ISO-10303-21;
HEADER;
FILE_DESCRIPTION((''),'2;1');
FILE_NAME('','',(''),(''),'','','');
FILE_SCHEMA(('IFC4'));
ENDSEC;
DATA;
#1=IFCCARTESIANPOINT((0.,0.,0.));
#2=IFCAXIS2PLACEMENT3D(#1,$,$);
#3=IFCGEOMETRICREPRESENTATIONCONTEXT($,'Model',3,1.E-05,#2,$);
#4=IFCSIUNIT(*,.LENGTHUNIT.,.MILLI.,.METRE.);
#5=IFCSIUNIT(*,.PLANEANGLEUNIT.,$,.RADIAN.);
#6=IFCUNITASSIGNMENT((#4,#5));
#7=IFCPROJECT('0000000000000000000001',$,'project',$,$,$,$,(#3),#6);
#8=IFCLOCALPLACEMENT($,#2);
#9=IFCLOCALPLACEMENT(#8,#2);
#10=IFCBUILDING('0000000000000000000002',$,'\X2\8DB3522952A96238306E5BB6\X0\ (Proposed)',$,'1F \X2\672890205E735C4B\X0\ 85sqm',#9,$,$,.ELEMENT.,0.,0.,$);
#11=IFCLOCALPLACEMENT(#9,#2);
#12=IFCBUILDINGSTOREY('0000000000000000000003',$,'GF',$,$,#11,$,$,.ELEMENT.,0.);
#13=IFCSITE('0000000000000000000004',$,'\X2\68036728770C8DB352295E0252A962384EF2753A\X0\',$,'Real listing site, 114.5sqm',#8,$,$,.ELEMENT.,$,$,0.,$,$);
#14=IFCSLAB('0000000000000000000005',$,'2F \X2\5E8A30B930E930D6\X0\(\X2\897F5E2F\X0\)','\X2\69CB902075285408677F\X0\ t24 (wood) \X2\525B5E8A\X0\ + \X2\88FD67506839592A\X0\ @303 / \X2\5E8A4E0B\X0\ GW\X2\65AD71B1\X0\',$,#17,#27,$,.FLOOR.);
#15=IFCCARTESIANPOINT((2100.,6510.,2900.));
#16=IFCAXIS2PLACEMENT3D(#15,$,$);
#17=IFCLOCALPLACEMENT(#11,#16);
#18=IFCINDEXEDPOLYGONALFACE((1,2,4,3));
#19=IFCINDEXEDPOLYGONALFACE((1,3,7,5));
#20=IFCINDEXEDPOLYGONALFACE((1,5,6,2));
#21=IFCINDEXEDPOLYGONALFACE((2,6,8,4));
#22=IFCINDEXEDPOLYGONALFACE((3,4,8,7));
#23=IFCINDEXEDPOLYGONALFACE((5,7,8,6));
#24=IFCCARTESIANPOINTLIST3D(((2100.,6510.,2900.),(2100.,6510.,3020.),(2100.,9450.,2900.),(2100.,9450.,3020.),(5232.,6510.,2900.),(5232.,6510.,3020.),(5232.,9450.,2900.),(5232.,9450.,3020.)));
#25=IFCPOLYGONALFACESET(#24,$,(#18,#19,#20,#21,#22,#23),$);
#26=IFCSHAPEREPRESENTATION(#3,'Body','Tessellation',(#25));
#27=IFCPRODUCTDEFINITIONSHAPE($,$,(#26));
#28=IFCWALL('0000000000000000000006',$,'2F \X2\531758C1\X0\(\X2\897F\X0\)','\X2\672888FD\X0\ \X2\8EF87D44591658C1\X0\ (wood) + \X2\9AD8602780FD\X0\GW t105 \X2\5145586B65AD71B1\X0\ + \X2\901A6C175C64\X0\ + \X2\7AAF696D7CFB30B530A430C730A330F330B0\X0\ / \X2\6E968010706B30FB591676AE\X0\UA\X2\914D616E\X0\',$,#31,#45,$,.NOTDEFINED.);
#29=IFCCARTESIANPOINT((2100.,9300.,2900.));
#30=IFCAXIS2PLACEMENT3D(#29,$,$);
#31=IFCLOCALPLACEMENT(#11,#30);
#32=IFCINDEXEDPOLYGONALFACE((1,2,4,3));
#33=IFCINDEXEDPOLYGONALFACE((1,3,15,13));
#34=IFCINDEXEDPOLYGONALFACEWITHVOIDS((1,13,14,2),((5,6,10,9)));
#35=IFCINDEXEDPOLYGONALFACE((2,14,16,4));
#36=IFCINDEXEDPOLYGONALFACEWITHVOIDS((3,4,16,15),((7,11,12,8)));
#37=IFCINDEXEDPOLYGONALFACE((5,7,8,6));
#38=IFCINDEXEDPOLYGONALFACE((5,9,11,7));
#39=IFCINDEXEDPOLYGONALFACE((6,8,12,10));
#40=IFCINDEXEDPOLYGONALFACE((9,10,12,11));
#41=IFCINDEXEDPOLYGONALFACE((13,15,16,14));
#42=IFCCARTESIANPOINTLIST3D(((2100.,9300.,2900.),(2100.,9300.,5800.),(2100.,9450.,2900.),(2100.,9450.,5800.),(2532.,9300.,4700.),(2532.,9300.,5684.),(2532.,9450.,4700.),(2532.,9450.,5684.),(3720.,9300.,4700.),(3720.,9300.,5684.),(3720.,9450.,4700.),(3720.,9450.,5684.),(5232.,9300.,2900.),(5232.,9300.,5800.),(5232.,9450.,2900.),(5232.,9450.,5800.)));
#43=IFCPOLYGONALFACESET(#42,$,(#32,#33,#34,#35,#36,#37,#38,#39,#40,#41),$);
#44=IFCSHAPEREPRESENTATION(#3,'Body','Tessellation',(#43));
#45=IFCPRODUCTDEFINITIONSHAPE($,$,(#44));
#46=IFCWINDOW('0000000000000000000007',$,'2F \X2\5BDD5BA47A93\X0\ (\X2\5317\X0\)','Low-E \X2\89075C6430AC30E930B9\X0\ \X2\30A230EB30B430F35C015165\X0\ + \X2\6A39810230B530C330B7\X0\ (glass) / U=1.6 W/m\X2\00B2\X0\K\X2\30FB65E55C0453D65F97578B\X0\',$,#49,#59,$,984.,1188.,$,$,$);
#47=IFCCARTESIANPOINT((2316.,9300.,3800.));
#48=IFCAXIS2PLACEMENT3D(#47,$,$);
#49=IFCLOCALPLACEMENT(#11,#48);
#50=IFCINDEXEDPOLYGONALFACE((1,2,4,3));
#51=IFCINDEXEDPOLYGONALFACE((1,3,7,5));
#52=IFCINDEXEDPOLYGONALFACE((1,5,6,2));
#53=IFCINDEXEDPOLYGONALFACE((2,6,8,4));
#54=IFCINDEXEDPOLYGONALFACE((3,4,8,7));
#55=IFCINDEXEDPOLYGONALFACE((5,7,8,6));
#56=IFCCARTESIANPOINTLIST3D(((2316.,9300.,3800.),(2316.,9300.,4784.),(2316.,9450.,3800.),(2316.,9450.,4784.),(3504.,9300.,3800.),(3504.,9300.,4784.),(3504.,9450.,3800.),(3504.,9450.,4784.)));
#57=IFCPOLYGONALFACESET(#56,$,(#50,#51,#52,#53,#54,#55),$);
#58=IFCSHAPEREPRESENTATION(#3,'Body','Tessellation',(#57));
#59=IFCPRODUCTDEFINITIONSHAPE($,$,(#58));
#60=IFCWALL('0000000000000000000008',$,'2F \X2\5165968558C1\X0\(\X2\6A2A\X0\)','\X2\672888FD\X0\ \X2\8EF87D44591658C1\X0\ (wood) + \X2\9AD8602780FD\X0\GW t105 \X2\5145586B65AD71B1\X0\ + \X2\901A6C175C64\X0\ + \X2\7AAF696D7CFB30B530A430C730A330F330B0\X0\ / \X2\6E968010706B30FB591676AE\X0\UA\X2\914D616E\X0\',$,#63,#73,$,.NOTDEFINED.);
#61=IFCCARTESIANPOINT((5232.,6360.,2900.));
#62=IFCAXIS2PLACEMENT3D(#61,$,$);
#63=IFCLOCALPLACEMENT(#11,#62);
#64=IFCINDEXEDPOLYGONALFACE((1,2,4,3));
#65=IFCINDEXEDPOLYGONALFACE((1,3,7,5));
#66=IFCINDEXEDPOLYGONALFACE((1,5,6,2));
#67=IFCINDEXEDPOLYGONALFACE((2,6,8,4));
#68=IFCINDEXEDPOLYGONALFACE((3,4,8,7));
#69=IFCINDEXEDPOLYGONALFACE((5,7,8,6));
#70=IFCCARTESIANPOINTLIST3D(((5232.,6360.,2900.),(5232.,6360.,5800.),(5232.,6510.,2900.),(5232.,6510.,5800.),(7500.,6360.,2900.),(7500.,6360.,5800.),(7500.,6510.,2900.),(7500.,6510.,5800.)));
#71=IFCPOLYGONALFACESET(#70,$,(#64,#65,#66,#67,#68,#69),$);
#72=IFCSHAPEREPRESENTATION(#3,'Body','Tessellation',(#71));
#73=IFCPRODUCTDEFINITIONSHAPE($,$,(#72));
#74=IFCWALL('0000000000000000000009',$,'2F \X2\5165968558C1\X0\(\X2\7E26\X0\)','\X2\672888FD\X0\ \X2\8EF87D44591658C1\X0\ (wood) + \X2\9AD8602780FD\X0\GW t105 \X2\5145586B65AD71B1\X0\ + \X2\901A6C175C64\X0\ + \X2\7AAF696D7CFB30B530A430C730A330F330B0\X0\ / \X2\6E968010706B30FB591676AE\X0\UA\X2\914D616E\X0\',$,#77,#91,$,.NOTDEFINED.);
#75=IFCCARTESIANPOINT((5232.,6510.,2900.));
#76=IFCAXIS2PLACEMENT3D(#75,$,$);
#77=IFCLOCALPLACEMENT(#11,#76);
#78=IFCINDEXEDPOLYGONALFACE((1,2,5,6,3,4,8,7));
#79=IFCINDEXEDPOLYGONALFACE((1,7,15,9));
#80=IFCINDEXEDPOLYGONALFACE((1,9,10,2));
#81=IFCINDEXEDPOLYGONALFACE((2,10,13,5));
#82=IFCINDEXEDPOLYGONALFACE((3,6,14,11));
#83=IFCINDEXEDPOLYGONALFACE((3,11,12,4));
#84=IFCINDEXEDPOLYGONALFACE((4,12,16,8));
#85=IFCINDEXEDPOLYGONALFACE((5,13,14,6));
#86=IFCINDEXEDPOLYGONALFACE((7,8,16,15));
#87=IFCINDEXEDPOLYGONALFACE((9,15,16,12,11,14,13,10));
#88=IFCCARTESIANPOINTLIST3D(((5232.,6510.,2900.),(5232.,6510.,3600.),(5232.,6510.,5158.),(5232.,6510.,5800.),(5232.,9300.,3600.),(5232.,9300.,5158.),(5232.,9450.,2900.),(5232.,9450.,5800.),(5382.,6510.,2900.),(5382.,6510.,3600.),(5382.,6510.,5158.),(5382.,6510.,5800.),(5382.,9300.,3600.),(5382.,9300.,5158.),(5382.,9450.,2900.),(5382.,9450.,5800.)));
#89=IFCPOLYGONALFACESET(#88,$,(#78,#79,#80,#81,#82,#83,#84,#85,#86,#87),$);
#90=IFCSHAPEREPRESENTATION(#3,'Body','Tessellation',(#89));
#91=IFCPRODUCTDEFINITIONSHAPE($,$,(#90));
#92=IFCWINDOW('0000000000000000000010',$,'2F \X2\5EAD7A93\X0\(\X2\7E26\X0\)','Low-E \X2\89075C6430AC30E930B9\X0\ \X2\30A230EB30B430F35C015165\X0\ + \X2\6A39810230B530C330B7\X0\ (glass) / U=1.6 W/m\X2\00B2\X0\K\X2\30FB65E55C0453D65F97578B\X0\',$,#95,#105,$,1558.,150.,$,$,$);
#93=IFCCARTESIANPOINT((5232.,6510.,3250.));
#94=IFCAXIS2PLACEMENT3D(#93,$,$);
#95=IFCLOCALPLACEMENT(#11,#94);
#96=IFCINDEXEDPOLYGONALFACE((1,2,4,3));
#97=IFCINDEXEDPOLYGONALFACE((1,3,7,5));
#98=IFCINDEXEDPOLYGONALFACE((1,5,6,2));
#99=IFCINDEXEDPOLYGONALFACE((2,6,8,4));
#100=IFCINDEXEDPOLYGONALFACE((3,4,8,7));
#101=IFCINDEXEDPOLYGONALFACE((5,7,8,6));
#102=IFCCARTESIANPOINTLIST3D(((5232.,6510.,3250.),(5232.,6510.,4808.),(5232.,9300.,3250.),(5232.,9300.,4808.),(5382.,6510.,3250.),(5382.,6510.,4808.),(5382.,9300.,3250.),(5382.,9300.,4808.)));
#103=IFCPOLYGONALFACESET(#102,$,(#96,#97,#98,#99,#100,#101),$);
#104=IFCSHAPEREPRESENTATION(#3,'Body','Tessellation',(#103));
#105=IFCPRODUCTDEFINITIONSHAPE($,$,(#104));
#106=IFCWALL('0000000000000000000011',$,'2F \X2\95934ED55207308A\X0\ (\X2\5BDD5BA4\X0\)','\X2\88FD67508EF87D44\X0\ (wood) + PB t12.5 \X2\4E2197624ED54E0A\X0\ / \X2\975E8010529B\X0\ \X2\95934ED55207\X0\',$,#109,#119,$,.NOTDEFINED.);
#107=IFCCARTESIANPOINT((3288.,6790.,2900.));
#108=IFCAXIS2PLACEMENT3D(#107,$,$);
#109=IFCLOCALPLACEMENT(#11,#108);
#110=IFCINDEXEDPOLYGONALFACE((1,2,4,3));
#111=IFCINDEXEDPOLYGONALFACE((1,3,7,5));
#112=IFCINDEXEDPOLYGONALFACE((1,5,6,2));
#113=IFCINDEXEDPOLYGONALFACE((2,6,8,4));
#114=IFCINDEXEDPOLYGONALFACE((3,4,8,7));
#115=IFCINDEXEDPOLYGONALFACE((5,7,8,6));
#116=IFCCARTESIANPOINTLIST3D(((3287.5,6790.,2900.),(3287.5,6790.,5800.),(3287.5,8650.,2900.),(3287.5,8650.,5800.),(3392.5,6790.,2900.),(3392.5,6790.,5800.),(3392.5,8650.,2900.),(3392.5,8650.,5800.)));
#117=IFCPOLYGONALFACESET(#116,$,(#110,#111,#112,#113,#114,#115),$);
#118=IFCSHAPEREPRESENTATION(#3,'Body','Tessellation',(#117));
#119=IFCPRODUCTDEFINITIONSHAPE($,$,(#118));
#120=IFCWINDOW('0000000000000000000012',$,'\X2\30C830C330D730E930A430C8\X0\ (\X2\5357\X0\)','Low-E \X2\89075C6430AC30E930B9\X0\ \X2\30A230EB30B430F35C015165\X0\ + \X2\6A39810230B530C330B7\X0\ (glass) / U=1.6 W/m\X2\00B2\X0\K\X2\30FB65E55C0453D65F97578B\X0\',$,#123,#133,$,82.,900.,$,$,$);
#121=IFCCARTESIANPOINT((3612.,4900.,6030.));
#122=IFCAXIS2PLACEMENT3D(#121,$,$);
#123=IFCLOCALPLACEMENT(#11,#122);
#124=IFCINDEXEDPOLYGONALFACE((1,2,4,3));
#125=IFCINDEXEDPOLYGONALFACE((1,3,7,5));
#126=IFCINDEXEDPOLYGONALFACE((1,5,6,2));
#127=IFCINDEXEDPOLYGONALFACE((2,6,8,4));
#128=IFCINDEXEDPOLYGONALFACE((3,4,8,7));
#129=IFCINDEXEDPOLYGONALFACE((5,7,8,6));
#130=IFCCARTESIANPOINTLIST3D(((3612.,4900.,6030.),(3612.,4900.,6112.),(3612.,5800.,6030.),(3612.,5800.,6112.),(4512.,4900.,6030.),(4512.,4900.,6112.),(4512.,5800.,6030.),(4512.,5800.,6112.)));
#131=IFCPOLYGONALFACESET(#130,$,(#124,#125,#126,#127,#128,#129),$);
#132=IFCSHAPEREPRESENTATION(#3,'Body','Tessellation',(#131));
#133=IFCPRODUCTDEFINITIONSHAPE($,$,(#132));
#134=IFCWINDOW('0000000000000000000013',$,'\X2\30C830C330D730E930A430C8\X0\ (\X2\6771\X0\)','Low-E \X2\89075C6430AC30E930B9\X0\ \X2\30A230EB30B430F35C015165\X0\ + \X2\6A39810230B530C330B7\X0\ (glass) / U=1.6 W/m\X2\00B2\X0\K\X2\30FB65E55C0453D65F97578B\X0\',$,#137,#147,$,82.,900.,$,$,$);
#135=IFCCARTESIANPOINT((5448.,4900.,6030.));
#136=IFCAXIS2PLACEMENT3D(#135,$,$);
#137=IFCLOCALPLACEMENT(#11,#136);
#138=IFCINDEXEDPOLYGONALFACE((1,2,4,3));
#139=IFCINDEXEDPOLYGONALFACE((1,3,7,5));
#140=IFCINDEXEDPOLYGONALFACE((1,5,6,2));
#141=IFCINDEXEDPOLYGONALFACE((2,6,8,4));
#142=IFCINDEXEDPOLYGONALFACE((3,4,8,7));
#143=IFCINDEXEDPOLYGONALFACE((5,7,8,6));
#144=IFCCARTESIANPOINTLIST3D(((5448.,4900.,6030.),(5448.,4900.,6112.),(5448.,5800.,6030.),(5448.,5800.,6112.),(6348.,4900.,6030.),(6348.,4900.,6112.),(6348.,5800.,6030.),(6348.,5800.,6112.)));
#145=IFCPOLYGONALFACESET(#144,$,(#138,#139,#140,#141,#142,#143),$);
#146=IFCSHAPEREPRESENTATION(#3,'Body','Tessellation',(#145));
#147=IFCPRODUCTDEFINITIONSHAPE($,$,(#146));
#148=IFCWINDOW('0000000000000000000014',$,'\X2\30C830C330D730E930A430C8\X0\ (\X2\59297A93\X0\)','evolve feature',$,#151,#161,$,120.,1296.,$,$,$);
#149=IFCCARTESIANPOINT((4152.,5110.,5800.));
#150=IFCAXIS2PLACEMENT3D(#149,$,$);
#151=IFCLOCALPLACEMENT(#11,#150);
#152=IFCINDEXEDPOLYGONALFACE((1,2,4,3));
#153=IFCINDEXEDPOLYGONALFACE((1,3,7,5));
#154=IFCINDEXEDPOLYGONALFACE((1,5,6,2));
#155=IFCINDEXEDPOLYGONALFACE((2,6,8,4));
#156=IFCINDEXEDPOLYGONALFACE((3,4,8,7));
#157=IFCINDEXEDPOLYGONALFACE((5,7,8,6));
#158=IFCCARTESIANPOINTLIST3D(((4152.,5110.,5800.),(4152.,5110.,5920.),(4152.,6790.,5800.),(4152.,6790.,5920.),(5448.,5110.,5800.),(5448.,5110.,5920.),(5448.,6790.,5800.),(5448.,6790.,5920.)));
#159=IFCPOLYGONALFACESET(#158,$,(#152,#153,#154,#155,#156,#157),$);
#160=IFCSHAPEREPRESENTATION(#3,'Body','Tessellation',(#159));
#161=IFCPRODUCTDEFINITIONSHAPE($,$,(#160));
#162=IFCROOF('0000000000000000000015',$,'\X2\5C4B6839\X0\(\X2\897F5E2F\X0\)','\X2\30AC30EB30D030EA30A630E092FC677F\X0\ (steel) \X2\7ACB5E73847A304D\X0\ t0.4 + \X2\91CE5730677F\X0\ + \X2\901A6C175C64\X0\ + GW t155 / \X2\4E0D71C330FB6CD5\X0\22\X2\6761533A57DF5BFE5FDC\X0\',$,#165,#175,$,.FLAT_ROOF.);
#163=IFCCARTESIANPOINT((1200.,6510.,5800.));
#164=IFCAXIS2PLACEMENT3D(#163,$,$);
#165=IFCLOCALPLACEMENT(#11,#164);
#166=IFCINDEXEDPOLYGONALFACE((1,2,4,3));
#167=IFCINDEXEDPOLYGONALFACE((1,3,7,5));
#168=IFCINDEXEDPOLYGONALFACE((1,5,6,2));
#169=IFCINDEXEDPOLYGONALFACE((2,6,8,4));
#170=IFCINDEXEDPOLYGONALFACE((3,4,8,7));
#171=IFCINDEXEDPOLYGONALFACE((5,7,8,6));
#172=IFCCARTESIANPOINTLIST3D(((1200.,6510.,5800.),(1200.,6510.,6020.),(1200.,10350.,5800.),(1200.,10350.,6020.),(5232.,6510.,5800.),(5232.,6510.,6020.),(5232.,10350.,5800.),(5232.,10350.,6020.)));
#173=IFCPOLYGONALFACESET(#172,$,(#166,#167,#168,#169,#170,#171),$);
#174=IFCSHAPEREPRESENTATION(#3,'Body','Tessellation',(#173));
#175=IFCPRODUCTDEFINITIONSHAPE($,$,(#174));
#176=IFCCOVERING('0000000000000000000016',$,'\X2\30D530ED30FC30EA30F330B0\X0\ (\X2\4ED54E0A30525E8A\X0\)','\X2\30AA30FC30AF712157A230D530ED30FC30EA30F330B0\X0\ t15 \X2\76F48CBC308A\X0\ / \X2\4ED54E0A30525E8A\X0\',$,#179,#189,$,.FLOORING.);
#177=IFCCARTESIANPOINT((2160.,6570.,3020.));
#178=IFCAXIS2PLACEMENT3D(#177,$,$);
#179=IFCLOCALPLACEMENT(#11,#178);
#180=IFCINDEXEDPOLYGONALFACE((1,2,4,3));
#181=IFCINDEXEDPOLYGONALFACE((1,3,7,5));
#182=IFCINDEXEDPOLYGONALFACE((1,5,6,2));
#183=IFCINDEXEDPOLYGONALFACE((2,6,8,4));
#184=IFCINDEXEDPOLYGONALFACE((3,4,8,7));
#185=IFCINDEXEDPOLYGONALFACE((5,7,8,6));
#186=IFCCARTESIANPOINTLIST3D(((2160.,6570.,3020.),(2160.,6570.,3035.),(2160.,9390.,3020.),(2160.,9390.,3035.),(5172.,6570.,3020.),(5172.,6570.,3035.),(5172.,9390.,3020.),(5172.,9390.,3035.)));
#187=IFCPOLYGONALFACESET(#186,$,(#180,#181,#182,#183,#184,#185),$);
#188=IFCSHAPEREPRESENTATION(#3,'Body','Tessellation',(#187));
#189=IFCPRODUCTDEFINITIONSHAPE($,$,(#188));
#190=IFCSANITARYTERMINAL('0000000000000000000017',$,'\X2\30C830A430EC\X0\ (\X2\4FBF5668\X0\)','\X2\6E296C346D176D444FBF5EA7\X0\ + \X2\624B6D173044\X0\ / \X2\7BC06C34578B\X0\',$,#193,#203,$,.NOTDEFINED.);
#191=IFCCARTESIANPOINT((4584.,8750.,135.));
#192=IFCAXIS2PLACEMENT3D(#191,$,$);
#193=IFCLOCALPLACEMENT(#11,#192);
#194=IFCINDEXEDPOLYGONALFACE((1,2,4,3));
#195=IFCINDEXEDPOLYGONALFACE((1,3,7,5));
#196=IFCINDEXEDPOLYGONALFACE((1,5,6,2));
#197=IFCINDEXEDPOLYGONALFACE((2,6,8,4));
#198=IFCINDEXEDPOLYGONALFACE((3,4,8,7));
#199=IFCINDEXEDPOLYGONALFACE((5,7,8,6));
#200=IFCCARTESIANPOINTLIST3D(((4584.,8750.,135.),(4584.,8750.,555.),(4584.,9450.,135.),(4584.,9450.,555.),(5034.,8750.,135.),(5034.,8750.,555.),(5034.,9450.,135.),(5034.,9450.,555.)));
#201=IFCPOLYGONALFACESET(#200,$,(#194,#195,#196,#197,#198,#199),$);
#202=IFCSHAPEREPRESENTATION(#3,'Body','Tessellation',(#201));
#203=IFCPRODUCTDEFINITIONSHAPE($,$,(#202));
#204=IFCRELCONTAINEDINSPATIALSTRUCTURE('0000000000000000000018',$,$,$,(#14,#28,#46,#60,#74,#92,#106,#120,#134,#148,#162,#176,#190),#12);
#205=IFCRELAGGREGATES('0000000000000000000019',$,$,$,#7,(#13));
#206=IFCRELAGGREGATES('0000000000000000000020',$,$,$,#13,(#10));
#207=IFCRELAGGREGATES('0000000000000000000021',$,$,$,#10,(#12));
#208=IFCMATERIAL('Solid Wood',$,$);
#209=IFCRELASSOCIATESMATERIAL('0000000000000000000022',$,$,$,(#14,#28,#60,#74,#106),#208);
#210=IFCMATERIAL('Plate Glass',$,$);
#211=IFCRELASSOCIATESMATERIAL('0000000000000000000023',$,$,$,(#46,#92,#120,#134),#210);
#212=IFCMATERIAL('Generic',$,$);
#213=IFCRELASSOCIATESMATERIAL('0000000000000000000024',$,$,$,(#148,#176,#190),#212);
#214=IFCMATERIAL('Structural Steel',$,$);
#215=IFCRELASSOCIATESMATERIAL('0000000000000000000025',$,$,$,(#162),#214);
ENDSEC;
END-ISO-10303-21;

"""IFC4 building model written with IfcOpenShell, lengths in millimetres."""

from ifc_helpers import new_model, si_unit, frame, frame_2d, origin, place, context, project, spatial, rectangle, extrude, material, element, fill, save


model = new_model("IFC4")

# Units and contexts
model_context = context("Model", 3, precision=1e-05, world=origin())
ifc_project = project(units=[si_unit("LENGTHUNIT", "METRE", prefix="MILLI"), si_unit("PLANEANGLEUNIT", "RADIAN")], contexts=[model_context])

# Site, building, storey
site_placement = place(None, origin())
site = spatial("IfcSite", under=ifc_project, at=site_placement, Name="栃木県足利市助戸仲町", ObjectType="Real listing site, 114.5sqm", CompositionType="ELEMENT", RefElevation=0.0)
building_placement = place(site_placement, origin())
building = spatial("IfcBuilding", under=site, at=building_placement, Name="足利助戸の家 (Proposed)", ObjectType="1F 木造平屋 85sqm", CompositionType="ELEMENT", ElevationOfRefHeight=0.0, ElevationOfTerrain=0.0)
storey_placement = place(building_placement, origin())
storey = spatial("IfcBuildingStorey", under=building, at=storey_placement, Name="GF", CompositionType="ELEMENT", Elevation=0.0)

# Slab
ifc_material_1 = material(Name="Solid Wood")
slab_placement = place(storey_placement, frame((2100.0, 6510.0, 2900.0)))
element("IfcSlab", 1, at=slab_placement, inside=storey, material=ifc_material_1, Name="2F 床スラブ(西帯)", Description="構造用合板 t24 (wood) 剛床 + 製材根太 @303 / 床下 GW断熱", PredefinedType="FLOOR", context=model_context, shape_type="SweptSolid", body=[
    extrude(rectangle(XDim=3132.0, YDim=2940.0, at=frame_2d((1566.0, 1470.0))), frame((2100.0, 6510.0, 2900.0)), (0.0, 0.0, 1.0), 120.0),
])

# Wall, opening, window
wall_1_placement = place(storey_placement, frame((2100.0, 9300.0, 2900.0)))
wall_1 = element("IfcWall", 2, at=wall_1_placement, inside=storey, material=ifc_material_1, Name="2F 北壁(西)", Description="木製 軸組外壁 (wood) + 高性能GW t105 充填断熱 + 通気層 + 窯業系サイディング / 準耐火・外皮UA配慮", PredefinedType="NOTDEFINED", context=model_context, shape_type="SweptSolid", body=[
    extrude(rectangle(XDim=3132.0, YDim=150.0, at=frame_2d((1566.0, 75.0))), frame((2100.0, 9300.0, 2900.0)), (0.0, 0.0, 1.0), 2900.0),
])
opening_1_placement = place(storey_placement, frame((2316.0, 9300.0, 3800.0)))
opening_1 = element("IfcOpeningElement", 3, at=opening_1_placement, cuts=wall_1, PredefinedType="NOTDEFINED", context=model_context, shape_type="SweptSolid", body=[
    extrude(rectangle(XDim=1188.0, YDim=150.0, at=frame_2d((594.0, 75.0))), frame((2316.0, 9300.0, 3800.0)), (0.0, 0.0, 1.0), 984.0),
])
ifc_material_2 = material(Name="Plate Glass")
window_1_placement = place(storey_placement, frame((2316.0, 9300.0, 3800.0)))
window_1 = element("IfcWindow", 4, at=window_1_placement, inside=storey, material=ifc_material_2, Name="2F 寝室窓 (北)", Description="Low-E 複層ガラス アルゴン封入 + 樹脂サッシ (glass) / U=1.6 W/m²K・日射取得型", OverallHeight=984.0, OverallWidth=1188.0, context=model_context, shape_type="SweptSolid", body=[
    extrude(rectangle(XDim=1188.0, YDim=150.0, at=frame_2d((594.0, 75.0))), frame((2316.0, 9300.0, 3800.0)), (0.0, 0.0, 1.0), 984.0),
])
fill(opening_1, window_1)

# Wall
wall_2_placement = place(storey_placement, frame((5232.0, 6360.0, 2900.0)))
element("IfcWall", 5, at=wall_2_placement, inside=storey, material=ifc_material_1, Name="2F 入隅壁(横)", Description="木製 軸組外壁 (wood) + 高性能GW t105 充填断熱 + 通気層 + 窯業系サイディング / 準耐火・外皮UA配慮", PredefinedType="NOTDEFINED", context=model_context, shape_type="SweptSolid", body=[
    extrude(rectangle(XDim=2268.0, YDim=150.0, at=frame_2d((1134.0, 75.0))), frame((5232.0, 6360.0, 2900.0)), (0.0, 0.0, 1.0), 2900.0),
])

# Wall, opening, window
wall_3_placement = place(storey_placement, frame((5232.0, 6510.0, 2900.0)))
wall_3 = element("IfcWall", 6, at=wall_3_placement, inside=storey, material=ifc_material_1, Name="2F 入隅壁(縦)", Description="木製 軸組外壁 (wood) + 高性能GW t105 充填断熱 + 通気層 + 窯業系サイディング / 準耐火・外皮UA配慮", PredefinedType="NOTDEFINED", context=model_context, shape_type="SweptSolid", body=[
    extrude(rectangle(XDim=150.0, YDim=2940.0, at=frame_2d((75.0, 1470.0))), frame((5232.0, 6510.0, 2900.0)), (0.0, 0.0, 1.0), 2900.0),
])
opening_2_placement = place(storey_placement, frame((5232.0, 6510.0, 3250.0)))
opening_2 = element("IfcOpeningElement", 7, at=opening_2_placement, cuts=wall_3, PredefinedType="NOTDEFINED", context=model_context, shape_type="SweptSolid", body=[
    extrude(rectangle(XDim=150.0, YDim=2790.0, at=frame_2d((75.0, 1395.0))), frame((5232.0, 6510.0, 3250.0)), (0.0, 0.0, 1.0), 1558.0),
])
window_2_placement = place(storey_placement, frame((5232.0, 6510.0, 3250.0)))
window_2 = element("IfcWindow", 8, at=window_2_placement, inside=storey, material=ifc_material_2, Name="2F 庭窓(縦)", Description="Low-E 複層ガラス アルゴン封入 + 樹脂サッシ (glass) / U=1.6 W/m²K・日射取得型", OverallHeight=1558.0, OverallWidth=150.0, context=model_context, shape_type="SweptSolid", body=[
    extrude(rectangle(XDim=150.0, YDim=2790.0, at=frame_2d((75.0, 1395.0))), frame((5232.0, 6510.0, 3250.0)), (0.0, 0.0, 1.0), 1558.0),
])
fill(opening_2, window_2)

# Wall
wall_4_placement = place(storey_placement, frame((3288.0, 6790.0, 2900.0)))
element("IfcWall", 9, at=wall_4_placement, inside=storey, material=ifc_material_1, Name="2F 間仕切り (寝室)", Description="製材軸組 (wood) + PB t12.5 両面仕上 / 非耐力 間仕切", PredefinedType="NOTDEFINED", context=model_context, shape_type="SweptSolid", body=[
    extrude(rectangle(XDim=105.0, YDim=1860.0, at=frame_2d((52.0, 930.0))), frame((3288.0, 6790.0, 2900.0)), (0.0, 0.0, 1.0), 2900.0),
])

# Windows
window_3_placement = place(storey_placement, frame((3612.0, 4900.0, 6030.0)))
element("IfcWindow", 10, at=window_3_placement, inside=storey, material=ifc_material_2, Name="トップライト (南)", Description="Low-E 複層ガラス アルゴン封入 + 樹脂サッシ (glass) / U=1.6 W/m²K・日射取得型", OverallHeight=82.0, OverallWidth=900.0, context=model_context, shape_type="SweptSolid", body=[
    extrude(rectangle(XDim=900.0, YDim=900.0, at=frame_2d((450.0, 450.0))), frame((3612.0, 4900.0, 6030.0)), (0.0, 0.0, 1.0), 82.0),
])
window_4_placement = place(storey_placement, frame((5448.0, 4900.0, 6030.0)))
element("IfcWindow", 11, at=window_4_placement, inside=storey, material=ifc_material_2, Name="トップライト (東)", Description="Low-E 複層ガラス アルゴン封入 + 樹脂サッシ (glass) / U=1.6 W/m²K・日射取得型", OverallHeight=82.0, OverallWidth=900.0, context=model_context, shape_type="SweptSolid", body=[
    extrude(rectangle(XDim=900.0, YDim=900.0, at=frame_2d((450.0, 450.0))), frame((5448.0, 4900.0, 6030.0)), (0.0, 0.0, 1.0), 82.0),
])
ifc_material_3 = material(Name="Generic")
window_5_placement = place(storey_placement, frame((4152.0, 5110.0, 5800.0)))
element("IfcWindow", 12, at=window_5_placement, inside=storey, material=ifc_material_3, Name="トップライト (天窓)", Description="evolve feature", OverallHeight=120.0, OverallWidth=1296.0, context=model_context, shape_type="SweptSolid", body=[
    extrude(rectangle(XDim=1296.0, YDim=1680.0, at=frame_2d((648.0, 840.0))), frame((4152.0, 5110.0, 5800.0)), (0.0, 0.0, 1.0), 120.0),
])

# Roof
ifc_material_4 = material(Name="Structural Steel")
for number, where, name in (
    (13, (1200.0, 6510.0, 5800.0), "屋根(西帯)"),
):
    element("IfcRoof", number, at=place(storey_placement, frame(where)), inside=storey, material=ifc_material_4, Name=name, Description="ガルバリウム鋼板 (steel) 立平葺き t0.4 + 野地板 + 通気層 + GW t155 / 不燃・法22条区域対応", PredefinedType="FLAT_ROOF", context=model_context, shape_type="SweptSolid", body=[
        extrude(rectangle(XDim=4032.0, YDim=3840.0, at=frame_2d((2016.0, 1920.0))), frame((1200.0, 6510.0, 5800.0)), (0.0, 0.0, 1.0), 220.0),
    ])

# Covering
covering_placement = place(storey_placement, frame((2160.0, 6570.0, 3020.0)))
element("IfcCovering", 14, at=covering_placement, inside=storey, material=ifc_material_3, Name="フローリング (仕上げ床)", Description="オーク無垢フローリング t15 直貼り / 仕上げ床", PredefinedType="FLOORING", context=model_context, shape_type="SweptSolid", body=[
    extrude(rectangle(XDim=3012.0, YDim=2820.0, at=frame_2d((1506.0, 1410.0))), frame((2160.0, 6570.0, 3020.0)), (0.0, 0.0, 1.0), 15.0),
])

# Sanitary terminal
sanitary_terminal_placement = place(storey_placement, frame((4584.0, 8750.0, 135.0)))
element("IfcSanitaryTerminal", 15, at=sanitary_terminal_placement, inside=storey, material=ifc_material_3, Name="トイレ (便器)", Description="温水洗浄便座 + 手洗い / 節水型", PredefinedType="NOTDEFINED", context=model_context, shape_type="SweptSolid", body=[
    extrude(rectangle(XDim=450.0, YDim=700.0, at=frame_2d((225.0, 350.0))), frame((4584.0, 8750.0, 135.0)), (0.0, 0.0, 1.0), 420.0),
])

save(model, "model.ifc")
